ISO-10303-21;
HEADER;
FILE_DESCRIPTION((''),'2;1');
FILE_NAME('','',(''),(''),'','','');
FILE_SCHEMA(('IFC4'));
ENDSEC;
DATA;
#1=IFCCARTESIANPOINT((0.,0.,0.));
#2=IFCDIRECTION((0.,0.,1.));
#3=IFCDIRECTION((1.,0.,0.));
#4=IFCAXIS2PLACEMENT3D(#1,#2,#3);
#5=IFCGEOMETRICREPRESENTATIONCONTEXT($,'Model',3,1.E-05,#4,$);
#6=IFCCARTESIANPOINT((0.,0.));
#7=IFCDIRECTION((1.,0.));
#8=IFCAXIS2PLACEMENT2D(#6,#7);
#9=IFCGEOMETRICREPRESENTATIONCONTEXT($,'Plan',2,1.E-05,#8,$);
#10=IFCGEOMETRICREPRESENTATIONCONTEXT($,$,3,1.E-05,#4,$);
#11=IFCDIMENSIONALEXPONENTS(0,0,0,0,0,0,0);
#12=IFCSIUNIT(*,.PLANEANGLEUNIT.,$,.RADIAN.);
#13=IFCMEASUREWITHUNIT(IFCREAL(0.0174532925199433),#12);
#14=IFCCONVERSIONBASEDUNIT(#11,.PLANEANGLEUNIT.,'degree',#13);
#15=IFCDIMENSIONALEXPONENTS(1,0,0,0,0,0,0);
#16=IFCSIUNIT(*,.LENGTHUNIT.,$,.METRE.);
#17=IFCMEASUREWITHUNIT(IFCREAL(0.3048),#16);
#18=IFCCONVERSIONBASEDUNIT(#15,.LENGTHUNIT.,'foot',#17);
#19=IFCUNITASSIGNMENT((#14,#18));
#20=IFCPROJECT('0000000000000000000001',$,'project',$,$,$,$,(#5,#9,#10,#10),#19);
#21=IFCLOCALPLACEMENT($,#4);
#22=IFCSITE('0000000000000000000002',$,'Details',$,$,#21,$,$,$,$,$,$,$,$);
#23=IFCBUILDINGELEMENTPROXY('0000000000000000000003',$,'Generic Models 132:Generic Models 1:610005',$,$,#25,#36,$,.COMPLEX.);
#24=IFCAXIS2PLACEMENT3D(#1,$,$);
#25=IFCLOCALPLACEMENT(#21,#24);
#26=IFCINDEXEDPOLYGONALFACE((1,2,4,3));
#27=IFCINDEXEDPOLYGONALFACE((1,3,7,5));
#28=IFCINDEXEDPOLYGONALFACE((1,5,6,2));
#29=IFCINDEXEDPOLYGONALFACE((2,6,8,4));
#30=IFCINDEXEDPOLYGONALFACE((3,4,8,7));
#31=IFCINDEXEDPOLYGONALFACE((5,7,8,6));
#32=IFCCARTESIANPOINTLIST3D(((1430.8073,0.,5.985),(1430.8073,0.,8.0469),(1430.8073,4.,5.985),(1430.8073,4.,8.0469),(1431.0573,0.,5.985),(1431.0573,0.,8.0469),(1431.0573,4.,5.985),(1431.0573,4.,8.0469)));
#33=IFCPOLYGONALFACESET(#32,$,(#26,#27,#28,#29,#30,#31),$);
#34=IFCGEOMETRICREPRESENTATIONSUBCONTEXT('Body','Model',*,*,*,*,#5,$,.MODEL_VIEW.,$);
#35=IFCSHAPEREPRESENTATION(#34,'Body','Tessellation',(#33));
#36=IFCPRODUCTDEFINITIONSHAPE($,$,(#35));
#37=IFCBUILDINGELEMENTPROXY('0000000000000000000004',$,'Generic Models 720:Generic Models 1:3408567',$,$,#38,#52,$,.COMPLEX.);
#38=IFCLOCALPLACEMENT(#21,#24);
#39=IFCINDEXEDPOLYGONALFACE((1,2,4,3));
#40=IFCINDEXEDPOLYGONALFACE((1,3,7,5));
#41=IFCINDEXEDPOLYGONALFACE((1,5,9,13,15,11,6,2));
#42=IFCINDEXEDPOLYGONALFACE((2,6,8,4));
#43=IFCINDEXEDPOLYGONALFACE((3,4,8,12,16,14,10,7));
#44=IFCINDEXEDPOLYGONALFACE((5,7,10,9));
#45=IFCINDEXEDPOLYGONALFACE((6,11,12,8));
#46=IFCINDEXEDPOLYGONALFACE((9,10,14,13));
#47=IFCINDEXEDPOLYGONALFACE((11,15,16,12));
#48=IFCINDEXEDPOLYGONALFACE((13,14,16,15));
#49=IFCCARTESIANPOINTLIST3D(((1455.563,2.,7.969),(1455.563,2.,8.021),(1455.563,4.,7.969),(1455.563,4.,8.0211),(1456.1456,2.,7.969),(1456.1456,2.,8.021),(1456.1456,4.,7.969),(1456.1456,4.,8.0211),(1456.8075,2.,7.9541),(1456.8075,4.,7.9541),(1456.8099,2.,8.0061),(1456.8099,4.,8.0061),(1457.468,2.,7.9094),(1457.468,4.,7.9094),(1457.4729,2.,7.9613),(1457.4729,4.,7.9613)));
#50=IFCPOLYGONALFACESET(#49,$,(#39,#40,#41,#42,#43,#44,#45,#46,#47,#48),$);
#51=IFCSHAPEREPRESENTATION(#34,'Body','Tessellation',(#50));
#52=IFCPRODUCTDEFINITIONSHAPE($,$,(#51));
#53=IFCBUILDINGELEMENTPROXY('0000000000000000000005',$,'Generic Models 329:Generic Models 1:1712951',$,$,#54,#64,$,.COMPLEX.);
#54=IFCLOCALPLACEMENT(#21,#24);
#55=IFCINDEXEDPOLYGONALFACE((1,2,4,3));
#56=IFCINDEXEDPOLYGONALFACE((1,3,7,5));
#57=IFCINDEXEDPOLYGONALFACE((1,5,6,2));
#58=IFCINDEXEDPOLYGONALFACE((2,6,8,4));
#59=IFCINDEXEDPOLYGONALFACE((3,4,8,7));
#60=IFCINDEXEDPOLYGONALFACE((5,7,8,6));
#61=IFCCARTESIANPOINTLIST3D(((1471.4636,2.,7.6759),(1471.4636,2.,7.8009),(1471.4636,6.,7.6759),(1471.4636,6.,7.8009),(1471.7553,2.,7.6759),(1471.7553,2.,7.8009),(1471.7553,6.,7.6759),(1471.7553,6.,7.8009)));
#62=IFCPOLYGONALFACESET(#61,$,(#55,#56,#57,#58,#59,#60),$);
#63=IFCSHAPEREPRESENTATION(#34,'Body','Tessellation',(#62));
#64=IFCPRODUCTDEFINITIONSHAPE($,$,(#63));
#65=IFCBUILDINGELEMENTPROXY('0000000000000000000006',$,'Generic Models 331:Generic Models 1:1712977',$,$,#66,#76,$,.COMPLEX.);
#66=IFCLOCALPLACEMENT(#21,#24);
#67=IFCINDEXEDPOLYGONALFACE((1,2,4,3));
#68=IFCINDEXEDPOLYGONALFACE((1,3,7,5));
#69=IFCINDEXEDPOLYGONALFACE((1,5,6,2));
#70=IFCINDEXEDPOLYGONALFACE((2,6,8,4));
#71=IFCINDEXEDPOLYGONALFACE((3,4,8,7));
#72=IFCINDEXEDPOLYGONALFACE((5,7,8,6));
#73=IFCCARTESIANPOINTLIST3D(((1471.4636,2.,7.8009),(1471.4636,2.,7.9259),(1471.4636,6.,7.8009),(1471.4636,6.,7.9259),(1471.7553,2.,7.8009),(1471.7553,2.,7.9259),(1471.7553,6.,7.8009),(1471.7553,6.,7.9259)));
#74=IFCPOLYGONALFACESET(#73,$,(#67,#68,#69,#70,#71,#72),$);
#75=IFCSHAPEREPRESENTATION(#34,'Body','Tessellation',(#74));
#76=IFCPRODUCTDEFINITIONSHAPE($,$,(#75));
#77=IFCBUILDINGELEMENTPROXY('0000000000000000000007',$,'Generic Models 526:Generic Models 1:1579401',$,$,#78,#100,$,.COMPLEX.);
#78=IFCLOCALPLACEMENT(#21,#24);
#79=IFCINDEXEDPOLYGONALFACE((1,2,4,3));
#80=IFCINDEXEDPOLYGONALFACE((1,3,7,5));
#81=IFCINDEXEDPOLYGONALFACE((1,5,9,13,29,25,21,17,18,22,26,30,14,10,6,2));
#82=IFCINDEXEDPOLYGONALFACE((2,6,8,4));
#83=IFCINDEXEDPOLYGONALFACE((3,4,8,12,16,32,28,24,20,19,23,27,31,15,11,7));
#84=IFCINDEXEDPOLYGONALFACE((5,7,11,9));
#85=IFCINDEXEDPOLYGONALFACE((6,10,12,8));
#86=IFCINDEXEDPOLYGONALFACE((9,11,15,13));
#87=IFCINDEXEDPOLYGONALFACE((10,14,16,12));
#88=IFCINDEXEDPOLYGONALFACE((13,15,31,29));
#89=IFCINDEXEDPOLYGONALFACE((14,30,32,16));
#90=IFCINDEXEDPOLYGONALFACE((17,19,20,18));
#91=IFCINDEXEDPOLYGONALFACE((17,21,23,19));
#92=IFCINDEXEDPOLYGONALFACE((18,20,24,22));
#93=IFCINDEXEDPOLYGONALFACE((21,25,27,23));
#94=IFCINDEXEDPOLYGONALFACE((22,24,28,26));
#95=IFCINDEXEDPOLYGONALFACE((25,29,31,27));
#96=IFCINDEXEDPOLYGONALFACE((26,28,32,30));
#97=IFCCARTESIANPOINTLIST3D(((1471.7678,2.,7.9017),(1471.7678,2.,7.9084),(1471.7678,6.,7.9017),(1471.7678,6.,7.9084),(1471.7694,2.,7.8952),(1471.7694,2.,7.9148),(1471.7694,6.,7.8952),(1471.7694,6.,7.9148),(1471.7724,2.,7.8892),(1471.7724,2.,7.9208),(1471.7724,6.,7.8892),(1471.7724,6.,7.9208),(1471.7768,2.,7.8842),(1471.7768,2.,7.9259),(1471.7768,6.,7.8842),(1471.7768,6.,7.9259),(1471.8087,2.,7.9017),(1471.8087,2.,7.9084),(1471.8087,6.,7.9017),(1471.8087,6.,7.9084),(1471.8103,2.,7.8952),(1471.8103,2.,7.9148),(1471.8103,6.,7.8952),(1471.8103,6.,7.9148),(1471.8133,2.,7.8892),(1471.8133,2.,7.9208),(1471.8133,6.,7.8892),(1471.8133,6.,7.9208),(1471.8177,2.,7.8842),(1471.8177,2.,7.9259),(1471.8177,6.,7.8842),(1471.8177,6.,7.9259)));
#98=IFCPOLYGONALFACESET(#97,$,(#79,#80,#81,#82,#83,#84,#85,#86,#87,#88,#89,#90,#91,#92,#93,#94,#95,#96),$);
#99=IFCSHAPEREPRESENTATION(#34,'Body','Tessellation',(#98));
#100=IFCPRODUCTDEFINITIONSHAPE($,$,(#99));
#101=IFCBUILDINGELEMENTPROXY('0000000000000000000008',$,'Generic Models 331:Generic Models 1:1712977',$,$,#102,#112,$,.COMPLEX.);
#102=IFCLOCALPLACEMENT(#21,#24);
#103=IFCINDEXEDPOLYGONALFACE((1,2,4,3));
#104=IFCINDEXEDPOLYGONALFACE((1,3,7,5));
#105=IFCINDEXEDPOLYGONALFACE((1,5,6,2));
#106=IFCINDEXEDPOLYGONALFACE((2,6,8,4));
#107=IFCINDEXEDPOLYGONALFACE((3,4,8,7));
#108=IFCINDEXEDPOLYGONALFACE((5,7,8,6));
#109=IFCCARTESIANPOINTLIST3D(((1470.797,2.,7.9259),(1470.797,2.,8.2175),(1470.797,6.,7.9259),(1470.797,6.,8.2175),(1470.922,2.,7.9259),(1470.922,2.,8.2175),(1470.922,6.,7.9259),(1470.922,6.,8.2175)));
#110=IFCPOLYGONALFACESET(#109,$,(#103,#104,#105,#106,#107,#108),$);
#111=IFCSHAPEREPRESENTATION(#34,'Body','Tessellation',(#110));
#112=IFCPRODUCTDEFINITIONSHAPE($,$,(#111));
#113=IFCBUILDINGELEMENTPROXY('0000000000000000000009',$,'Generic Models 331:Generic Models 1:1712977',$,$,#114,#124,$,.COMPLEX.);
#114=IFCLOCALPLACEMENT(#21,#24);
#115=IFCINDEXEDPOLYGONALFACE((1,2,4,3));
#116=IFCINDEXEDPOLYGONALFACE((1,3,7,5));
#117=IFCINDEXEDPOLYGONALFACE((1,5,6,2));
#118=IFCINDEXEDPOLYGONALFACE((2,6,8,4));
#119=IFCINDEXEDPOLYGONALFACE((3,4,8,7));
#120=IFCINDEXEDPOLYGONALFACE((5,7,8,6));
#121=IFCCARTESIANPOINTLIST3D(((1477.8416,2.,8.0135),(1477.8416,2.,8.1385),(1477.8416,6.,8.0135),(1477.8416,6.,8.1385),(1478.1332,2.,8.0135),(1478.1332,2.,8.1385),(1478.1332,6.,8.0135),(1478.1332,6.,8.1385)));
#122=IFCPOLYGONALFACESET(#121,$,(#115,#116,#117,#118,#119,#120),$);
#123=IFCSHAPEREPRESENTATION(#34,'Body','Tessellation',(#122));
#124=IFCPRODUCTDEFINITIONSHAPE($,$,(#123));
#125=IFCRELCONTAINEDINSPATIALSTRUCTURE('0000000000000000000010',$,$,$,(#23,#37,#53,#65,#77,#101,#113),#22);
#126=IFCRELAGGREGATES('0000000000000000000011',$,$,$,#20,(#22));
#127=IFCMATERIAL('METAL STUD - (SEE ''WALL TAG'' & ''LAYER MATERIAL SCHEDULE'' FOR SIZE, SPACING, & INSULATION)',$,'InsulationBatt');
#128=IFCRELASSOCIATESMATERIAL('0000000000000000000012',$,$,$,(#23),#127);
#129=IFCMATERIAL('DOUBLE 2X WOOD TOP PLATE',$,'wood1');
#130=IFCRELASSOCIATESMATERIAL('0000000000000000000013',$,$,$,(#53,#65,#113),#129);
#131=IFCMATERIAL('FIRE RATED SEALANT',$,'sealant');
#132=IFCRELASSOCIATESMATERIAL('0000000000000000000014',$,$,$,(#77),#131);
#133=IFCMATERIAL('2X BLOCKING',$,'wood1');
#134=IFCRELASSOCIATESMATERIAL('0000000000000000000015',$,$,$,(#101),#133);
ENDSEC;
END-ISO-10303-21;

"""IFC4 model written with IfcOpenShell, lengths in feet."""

from ifc_helpers import new_model, entity, si_unit, converted_unit, frame, origin_with_axes, origin_2d_with_axis, place, context, subcontext, project, spatial, polyline, line, indexed_curve, outline, extrude, material, element, save


model = new_model("IFC4")

# Units and contexts
model_context = context("Model", 3, precision=1e-05, world=origin_with_axes())
plan_context = context("Plan", 2, precision=1e-05, world=origin_2d_with_axis())
context_of_model = context(None, 3, precision=1e-05, world=origin_with_axes())
body_context = subcontext(model_context, "Body", "Model", "MODEL_VIEW")
ifc_project = project(units=[converted_unit("PLANEANGLEUNIT", "degree", entity("IfcReal", 0.0174532925199433), si_unit("PLANEANGLEUNIT", "RADIAN"), dimensions=[0, 0, 0, 0, 0, 0, 0]), converted_unit("LENGTHUNIT", "foot", entity("IfcReal", 0.3048), si_unit("LENGTHUNIT", "METRE"), dimensions=[1, 0, 0, 0, 0, 0, 0])], contexts=[model_context, plan_context, context_of_model, context_of_model])

# Site
site_placement = place(None, origin_with_axes())
site = spatial("IfcSite", under=ifc_project, at=site_placement, Name="Details")

# Building element proxies
ifc_material_1 = material(Name="METAL STUD - (SEE 'WALL TAG' & 'LAYER MATERIAL SCHEDULE' FOR SIZE, SPACING, & INSULATION)", Category="InsulationBatt")
proxy_1_placement = place(site_placement, frame((1430.8073, 4.0, 5.985), z_axis=(0.0, -1.0, 0.0), x_axis=(0.0, 0.0, 1.0)))
element("IfcBuildingElementProxy", 1, at=proxy_1_placement, inside=site, material=ifc_material_1, Name="Generic Models 132:Generic Models 1:610005", PredefinedType="COMPLEX", context=body_context, shape_type="SweptSolid", body=[
    extrude(outline(polyline([(-1.0309, -0.125), (1.0309, -0.125), (1.0309, 0.125), (-1.0309, 0.125), (-1.0309, -0.125)])), frame((1.0309, -0.125, 0.0), z_axis=(0.0, 0.0, -1.0), x_axis=(1.0, 0.0, 0.0)), (0.0, 0.0, -1.0), 4.0),
])
proxy_2_placement = place(site_placement, frame((1455.563, 6.0, 7.9094), z_axis=(0.0, -1.0, 0.0), x_axis=(0.0, 0.0, 1.0)))
element("IfcBuildingElementProxy", 2, at=proxy_2_placement, inside=site, Name="Generic Models 720:Generic Models 1:3408567", PredefinedType="COMPLEX", context=body_context, shape_type="SweptSolid", body=[
    extrude(outline(polyline([(-0.0074, -0.9339), (0.0447, -0.9339), (0.0447, -0.3513), (0.0297, 0.313), (-0.0151, 0.9759), (-0.0669, 0.9711), (-0.0223, 0.3105), (-0.0074, -0.3513), (-0.0074, -0.9339)])), frame((0.0669, -0.9339, 2.0), z_axis=(0.000003, 0.0, -1.0), x_axis=(1.0, 0.0, 0.0)), (0.0, 0.0, -1.0), 2.0),
])
ifc_material_2 = material(Name="DOUBLE 2X WOOD TOP PLATE", Category="wood1")
proxy_3_placement = place(site_placement, frame((1471.4636, 6.0, 7.6759), z_axis=(0.0, -1.0, 0.0), x_axis=(0.0, 0.0, 1.0)))
element("IfcBuildingElementProxy", 3, at=proxy_3_placement, inside=site, material=ifc_material_2, Name="Generic Models 329:Generic Models 1:1712951", PredefinedType="COMPLEX", context=body_context, shape_type="SweptSolid", body=[
    extrude(outline(indexed_curve([(-0.1458, -0.0625), (0.1458, -0.0625), (0.1458, 0.0625), (-0.1458, 0.0625)], segments=[line(3, 2), line(2, 1), line(1, 4), line(4, 3)], self_intersect=False)), frame((0.0625, -0.1458, 0.0), z_axis=(0.0, 0.0, -1.0), x_axis=(0.0, 1.0, 0.0)), (0.0, 0.0, -1.0), 4.0),
])
proxy_4_placement = place(site_placement, frame((1471.4636, 6.0, 7.8009), z_axis=(0.0, -1.0, 0.0), x_axis=(0.0, 0.0, 1.0)))
element("IfcBuildingElementProxy", 4, at=proxy_4_placement, inside=site, material=ifc_material_2, Name="Generic Models 331:Generic Models 1:1712977", PredefinedType="COMPLEX", context=body_context, shape_type="SweptSolid", body=[
    extrude(outline(polyline([(-0.1458, -0.0625), (0.1458, -0.0625), (0.1458, 0.0625), (-0.1458, 0.0625), (-0.1458, -0.0625)])), frame((0.0625, -0.1458, 0.0), z_axis=(0.0, 0.0, -1.0), x_axis=(0.0, 1.0, 0.0)), (0.0, 0.0, -1.0), 4.0),
])
ifc_material_3 = material(Name="FIRE RATED SEALANT", Category="sealant")
proxy_5_placement = place(site_placement, frame((1471.8177, 6.0, 7.9259), z_axis=(0.0, -1.0, 0.0), x_axis=(0.0, 0.0, -1.0)))
element("IfcBuildingElementProxy", 5, at=proxy_5_placement, inside=site, material=ifc_material_3, Name="Generic Models 526:Generic Models 1:1579401", PredefinedType="COMPLEX", context=body_context, shape_type="SweptSolid", body=[
    extrude(outline(indexed_curve([(0.029, -0.0004), (0.0282, -0.007), (0.026, -0.0133), (0.0223, -0.0189), (0.0175, -0.0235), (0.0117, -0.0268), (0.0052, -0.0286), (-0.0014, -0.0289), (-0.0294, 0.0009), (-0.0228, 0.0012), (-0.0163, 0.0031), (-0.0105, 0.0064), (-0.0057, 0.0109), (-0.002, 0.0165), (0.0002, 0.0228), (0.001, 0.0294)], segments=[line(2, 1), line(1, 16), line(16, 15), line(15, 14), line(14, 13), line(13, 12), line(12, 11), line(11, 10), line(10, 9), line(9, 8), line(8, 7), line(7, 6), line(6, 5), line(5, 4), line(4, 3), line(3, 2)], self_intersect=False)), frame((0.0208, -0.0208, 0.0), z_axis=(0.0, 0.0, -1.0), x_axis=(-0.729168, -0.684334, 0.0)), (0.0, 0.0, -1.0), 4.0),
])
ifc_material_4 = material(Name="2X BLOCKING", Category="wood1")
proxy_6_placement = place(site_placement, frame((1470.922, 6.0, 7.9259), z_axis=(0.0, -1.0, 0.0), x_axis=(-1.0, 0.0, 0.0)))
element("IfcBuildingElementProxy", 6, at=proxy_6_placement, inside=site, material=ifc_material_4, Name="Generic Models 331:Generic Models 1:1712977", PredefinedType="COMPLEX", context=body_context, shape_type="SweptSolid", body=[
    extrude(outline(polyline([(-0.1458, -0.0625), (0.1458, -0.0625), (0.1458, 0.0625), (-0.1458, 0.0625), (-0.1458, -0.0625)])), frame((0.0625, -0.1458, 0.0), z_axis=(0.0, 0.0, -1.0), x_axis=(0.0, -1.0, 0.0)), (0.0, 0.0, -1.0), 4.0),
])
proxy_7_placement = place(site_placement, frame((1477.8416, 6.0, 8.0135), z_axis=(0.0, -1.0, 0.0), x_axis=(0.0, 0.0, 1.0)))
element("IfcBuildingElementProxy", 7, at=proxy_7_placement, inside=site, material=ifc_material_2, Name="Generic Models 331:Generic Models 1:1712977", PredefinedType="COMPLEX", context=body_context, shape_type="SweptSolid", body=[
    extrude(outline(polyline([(-0.1458, -0.0625), (0.1458, -0.0625), (0.1458, 0.0625), (-0.1458, 0.0625), (-0.1458, -0.0625)])), frame((0.0625, -0.1458, 0.0), z_axis=(0.0, 0.0, -1.0), x_axis=(0.0, -1.0, 0.0)), (0.0, 0.0, -1.0), 4.0),
])

save(model, "model.ifc")
